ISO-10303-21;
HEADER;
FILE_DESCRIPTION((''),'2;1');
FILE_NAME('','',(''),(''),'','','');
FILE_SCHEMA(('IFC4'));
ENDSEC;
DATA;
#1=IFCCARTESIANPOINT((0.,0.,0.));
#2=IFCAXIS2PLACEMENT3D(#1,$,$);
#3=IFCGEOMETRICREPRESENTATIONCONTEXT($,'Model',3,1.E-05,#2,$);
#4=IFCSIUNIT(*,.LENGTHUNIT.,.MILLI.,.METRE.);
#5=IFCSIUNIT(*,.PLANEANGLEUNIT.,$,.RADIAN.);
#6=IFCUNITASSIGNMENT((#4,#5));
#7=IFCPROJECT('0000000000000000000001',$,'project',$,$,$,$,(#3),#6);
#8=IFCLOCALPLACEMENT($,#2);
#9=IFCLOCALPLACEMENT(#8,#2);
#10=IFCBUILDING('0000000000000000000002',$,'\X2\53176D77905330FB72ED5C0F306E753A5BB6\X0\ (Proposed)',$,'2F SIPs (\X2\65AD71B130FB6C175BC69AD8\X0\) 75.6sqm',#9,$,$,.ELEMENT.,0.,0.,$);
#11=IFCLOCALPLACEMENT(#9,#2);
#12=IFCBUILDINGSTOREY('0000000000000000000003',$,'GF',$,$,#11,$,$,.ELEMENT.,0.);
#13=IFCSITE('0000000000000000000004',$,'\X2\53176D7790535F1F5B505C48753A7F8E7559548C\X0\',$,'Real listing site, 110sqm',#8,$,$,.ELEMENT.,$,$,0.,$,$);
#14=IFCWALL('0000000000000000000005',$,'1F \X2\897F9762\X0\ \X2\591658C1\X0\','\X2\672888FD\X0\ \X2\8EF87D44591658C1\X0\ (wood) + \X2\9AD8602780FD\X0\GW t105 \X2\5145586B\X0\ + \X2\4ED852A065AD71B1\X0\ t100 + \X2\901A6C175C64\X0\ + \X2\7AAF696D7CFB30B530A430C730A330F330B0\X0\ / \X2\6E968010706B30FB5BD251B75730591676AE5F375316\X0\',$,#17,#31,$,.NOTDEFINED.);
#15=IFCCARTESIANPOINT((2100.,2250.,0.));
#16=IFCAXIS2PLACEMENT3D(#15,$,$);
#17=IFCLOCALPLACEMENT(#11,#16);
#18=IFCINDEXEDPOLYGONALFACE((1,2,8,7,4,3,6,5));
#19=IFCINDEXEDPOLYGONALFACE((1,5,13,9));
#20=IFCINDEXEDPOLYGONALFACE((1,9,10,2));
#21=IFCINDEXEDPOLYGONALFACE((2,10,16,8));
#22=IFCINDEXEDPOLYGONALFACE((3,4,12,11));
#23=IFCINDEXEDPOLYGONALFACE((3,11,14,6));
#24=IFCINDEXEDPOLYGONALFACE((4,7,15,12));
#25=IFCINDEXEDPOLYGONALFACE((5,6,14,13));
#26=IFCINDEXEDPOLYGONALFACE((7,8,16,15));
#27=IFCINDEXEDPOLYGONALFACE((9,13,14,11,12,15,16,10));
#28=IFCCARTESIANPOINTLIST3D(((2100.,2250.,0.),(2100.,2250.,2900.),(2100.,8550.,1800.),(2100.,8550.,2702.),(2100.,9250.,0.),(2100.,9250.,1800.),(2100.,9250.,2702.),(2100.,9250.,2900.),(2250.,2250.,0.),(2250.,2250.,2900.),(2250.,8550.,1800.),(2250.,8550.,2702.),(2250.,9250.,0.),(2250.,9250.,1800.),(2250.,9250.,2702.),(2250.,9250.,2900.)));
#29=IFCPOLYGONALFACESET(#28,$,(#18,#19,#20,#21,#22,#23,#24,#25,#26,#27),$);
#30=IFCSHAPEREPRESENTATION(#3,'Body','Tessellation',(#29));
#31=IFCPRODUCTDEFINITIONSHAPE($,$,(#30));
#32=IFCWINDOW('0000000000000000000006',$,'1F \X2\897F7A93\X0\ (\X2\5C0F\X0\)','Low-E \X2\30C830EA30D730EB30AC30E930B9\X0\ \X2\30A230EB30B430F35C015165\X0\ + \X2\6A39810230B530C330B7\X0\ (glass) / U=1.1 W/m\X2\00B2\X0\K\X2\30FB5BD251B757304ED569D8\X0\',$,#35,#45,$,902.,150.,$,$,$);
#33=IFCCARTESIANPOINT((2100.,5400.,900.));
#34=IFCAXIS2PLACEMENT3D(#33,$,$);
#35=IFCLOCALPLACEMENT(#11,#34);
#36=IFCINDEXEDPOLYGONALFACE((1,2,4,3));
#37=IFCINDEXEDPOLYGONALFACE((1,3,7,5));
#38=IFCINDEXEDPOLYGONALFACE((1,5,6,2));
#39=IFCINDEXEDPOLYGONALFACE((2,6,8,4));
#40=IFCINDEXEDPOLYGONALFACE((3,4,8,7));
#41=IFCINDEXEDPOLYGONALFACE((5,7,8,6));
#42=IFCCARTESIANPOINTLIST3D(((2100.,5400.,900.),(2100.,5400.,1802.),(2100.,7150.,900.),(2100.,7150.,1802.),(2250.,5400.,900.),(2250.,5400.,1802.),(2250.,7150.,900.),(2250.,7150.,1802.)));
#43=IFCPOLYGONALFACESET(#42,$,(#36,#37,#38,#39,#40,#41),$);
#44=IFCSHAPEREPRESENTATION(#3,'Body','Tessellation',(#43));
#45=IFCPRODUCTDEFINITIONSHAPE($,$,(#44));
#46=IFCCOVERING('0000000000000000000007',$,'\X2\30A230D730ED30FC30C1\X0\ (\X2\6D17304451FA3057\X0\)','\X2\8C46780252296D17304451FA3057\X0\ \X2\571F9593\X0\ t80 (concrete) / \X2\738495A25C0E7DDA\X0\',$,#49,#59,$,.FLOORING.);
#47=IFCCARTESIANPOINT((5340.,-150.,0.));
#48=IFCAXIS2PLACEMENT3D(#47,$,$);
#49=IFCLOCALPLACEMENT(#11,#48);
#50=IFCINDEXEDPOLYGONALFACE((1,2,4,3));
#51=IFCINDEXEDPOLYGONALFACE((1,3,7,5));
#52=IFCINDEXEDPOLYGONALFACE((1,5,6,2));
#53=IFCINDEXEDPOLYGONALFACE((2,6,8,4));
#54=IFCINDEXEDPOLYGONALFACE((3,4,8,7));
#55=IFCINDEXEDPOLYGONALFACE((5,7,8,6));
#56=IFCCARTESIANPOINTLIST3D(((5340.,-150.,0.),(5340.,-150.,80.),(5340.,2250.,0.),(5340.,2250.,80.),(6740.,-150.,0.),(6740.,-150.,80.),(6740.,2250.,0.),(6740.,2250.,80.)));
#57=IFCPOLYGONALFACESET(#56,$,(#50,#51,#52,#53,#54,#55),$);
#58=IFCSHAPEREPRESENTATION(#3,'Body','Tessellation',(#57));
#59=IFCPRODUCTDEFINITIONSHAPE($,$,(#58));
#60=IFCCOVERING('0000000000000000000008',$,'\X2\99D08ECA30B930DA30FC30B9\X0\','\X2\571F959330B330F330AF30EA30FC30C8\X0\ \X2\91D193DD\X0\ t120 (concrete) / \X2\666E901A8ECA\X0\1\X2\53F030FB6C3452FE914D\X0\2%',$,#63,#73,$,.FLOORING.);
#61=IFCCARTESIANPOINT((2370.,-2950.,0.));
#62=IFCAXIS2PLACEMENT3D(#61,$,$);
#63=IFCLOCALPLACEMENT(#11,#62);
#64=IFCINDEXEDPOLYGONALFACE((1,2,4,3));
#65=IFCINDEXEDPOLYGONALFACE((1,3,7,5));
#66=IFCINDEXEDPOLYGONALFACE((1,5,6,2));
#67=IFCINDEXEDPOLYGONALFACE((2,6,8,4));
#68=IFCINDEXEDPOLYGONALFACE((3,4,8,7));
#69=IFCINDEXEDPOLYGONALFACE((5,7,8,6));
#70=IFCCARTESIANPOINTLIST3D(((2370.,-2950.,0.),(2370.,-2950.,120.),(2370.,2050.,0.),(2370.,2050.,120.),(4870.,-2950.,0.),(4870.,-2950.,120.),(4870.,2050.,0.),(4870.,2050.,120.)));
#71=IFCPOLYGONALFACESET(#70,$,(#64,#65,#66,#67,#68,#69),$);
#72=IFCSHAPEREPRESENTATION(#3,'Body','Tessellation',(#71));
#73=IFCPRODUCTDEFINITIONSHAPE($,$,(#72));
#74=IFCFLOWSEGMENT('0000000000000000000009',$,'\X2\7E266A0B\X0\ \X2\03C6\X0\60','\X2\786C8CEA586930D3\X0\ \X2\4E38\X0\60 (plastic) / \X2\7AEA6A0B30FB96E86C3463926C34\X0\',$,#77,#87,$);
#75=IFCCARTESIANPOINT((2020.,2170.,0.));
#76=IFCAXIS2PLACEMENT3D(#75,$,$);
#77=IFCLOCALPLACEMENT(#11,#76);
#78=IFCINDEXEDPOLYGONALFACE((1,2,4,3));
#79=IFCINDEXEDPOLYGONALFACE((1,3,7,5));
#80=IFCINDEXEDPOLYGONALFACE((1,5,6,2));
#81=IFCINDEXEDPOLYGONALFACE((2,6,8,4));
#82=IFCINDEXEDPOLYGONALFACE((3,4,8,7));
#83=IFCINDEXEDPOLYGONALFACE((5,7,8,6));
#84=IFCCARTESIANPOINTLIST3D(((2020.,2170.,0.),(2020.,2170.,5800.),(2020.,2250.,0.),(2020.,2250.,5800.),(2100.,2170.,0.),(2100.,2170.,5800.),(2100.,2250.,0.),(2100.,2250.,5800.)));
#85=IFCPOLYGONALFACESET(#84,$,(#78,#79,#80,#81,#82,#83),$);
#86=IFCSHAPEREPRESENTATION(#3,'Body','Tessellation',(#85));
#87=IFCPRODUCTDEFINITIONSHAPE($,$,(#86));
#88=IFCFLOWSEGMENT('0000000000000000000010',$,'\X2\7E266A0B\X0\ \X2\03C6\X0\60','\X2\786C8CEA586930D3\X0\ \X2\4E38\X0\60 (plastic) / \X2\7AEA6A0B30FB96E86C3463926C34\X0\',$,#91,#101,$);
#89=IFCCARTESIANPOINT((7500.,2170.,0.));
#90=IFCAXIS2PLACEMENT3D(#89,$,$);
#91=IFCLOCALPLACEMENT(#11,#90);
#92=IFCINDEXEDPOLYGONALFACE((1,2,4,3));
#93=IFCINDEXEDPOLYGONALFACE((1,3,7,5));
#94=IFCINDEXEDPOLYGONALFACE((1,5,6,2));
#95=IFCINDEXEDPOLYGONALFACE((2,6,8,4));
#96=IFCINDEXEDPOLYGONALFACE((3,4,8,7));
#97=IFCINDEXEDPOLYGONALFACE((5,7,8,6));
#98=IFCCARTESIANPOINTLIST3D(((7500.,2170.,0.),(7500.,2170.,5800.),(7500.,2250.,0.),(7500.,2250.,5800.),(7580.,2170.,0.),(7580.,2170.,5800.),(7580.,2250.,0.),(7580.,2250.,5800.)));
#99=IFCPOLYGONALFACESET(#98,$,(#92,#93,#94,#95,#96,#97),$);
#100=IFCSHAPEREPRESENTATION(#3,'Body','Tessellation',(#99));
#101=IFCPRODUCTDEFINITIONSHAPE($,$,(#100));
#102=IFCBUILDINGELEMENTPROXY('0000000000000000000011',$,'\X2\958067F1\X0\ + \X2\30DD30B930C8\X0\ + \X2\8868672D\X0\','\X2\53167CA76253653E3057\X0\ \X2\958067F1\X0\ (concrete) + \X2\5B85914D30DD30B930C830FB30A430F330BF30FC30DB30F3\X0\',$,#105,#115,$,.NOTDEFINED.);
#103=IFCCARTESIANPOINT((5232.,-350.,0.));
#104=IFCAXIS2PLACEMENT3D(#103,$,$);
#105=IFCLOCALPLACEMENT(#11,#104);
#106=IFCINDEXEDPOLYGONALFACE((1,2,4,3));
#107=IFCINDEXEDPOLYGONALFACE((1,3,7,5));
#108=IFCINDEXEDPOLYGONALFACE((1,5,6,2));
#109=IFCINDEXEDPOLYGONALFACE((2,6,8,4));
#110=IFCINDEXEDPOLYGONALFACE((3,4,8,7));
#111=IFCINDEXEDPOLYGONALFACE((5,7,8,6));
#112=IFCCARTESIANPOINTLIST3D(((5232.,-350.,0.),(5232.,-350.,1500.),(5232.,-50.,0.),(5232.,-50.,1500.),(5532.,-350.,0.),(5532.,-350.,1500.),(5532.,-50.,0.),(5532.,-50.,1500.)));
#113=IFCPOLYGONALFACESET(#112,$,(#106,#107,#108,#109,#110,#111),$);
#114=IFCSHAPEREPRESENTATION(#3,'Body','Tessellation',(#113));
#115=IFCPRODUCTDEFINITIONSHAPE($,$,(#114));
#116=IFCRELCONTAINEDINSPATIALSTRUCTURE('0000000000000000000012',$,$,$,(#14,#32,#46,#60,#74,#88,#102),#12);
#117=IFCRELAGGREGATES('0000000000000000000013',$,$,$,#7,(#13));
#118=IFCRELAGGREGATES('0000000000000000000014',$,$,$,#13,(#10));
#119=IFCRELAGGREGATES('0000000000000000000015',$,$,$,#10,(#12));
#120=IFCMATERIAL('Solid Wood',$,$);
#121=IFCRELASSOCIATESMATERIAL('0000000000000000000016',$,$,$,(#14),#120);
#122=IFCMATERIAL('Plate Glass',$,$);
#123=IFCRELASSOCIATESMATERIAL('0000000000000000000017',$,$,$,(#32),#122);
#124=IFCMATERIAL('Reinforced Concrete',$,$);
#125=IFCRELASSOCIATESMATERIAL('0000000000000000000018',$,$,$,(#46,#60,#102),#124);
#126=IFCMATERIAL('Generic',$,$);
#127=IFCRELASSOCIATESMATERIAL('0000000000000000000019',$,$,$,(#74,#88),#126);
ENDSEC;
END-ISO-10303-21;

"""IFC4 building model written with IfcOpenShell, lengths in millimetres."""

from ifc_helpers import new_model, si_unit, frame, frame_2d, origin, place, context, project, spatial, rectangle, extrude, material, element, fill, save


model = new_model("IFC4")

# Units and contexts
model_context = context("Model", 3, precision=1e-05, world=origin())
ifc_project = project(units=[si_unit("LENGTHUNIT", "METRE", prefix="MILLI"), si_unit("PLANEANGLEUNIT", "RADIAN")], contexts=[model_context])

# Site, building, storey
site_placement = place(None, origin())
site = spatial("IfcSite", under=ifc_project, at=site_placement, Name="北海道弟子屈町美留和", ObjectType="Real listing site, 110sqm", CompositionType="ELEMENT", RefElevation=0.0)
building_placement = place(site_placement, origin())
building = spatial("IfcBuilding", under=site, at=building_placement, Name="北海道・狭小の町家 (Proposed)", ObjectType="2F SIPs (断熱・気密高) 75.6sqm", CompositionType="ELEMENT", ElevationOfRefHeight=0.0, ElevationOfTerrain=0.0)
storey_placement = place(building_placement, origin())
storey = spatial("IfcBuildingStorey", under=building, at=storey_placement, Name="GF", CompositionType="ELEMENT", Elevation=0.0)

# Shared definitions
ifc_material_1 = material(Name="Solid Wood")

# Shared definitions
ifc_material_2 = material(Name="Reinforced Concrete")

# Shared definitions
ifc_material_3 = material(Name="Plate Glass")

# Wall, opening, window
wall_1_placement = place(storey_placement, frame((2100.0, 2250.0, 0.0)))
wall_1 = element("IfcWall", 1, at=wall_1_placement, inside=storey, material=ifc_material_1, Name="1F 西面 外壁", Description="木製 軸組外壁 (wood) + 高性能GW t105 充填 + 付加断熱 t100 + 通気層 + 窯業系サイディング / 準耐火・寒冷地外皮強化", PredefinedType="NOTDEFINED", context=model_context, shape_type="SweptSolid", body=[
    extrude(rectangle(XDim=150.0, YDim=7000.0, at=frame_2d((75.0, 3500.0))), frame((2100.0, 2250.0, 0.0)), (0.0, 0.0, 1.0), 2900.0),
])
opening_1_placement = place(storey_placement, frame((2100.0, 5400.0, 900.0)))
opening_1 = element("IfcOpeningElement", 2, at=opening_1_placement, cuts=wall_1, PredefinedType="NOTDEFINED", context=model_context, shape_type="SweptSolid", body=[
    extrude(rectangle(XDim=150.0, YDim=1750.0, at=frame_2d((75.0, 875.0))), frame((2100.0, 5400.0, 900.0)), (0.0, 0.0, 1.0), 902.0),
])
window_1_placement = place(storey_placement, frame((2100.0, 5400.0, 900.0)))
window_1 = element("IfcWindow", 3, at=window_1_placement, inside=storey, material=ifc_material_3, Name="1F 西窓 (小)", Description="Low-E トリプルガラス アルゴン封入 + 樹脂サッシ (glass) / U=1.1 W/m²K・寒冷地仕様", OverallHeight=902.0, OverallWidth=150.0, context=model_context, shape_type="SweptSolid", body=[
    extrude(rectangle(XDim=150.0, YDim=1750.0, at=frame_2d((75.0, 875.0))), frame((2100.0, 5400.0, 900.0)), (0.0, 0.0, 1.0), 902.0),
])
fill(opening_1, window_1)

# Coverings
covering_1_placement = place(storey_placement, frame((5340.0, -150.0, 0.0)))
element("IfcCovering", 4, at=covering_1_placement, inside=storey, material=ifc_material_2, Name="アプローチ (洗い出し)", Description="豆砂利洗い出し 土間 t80 (concrete) / 玄関導線", PredefinedType="FLOORING", context=model_context, shape_type="SweptSolid", body=[
    extrude(rectangle(XDim=1400.0, YDim=2400.0, at=frame_2d((700.0, 1200.0))), frame((5340.0, -150.0, 0.0)), (0.0, 0.0, 1.0), 80.0),
])
covering_2_placement = place(storey_placement, frame((2370.0, -2950.0, 0.0)))
element("IfcCovering", 5, at=covering_2_placement, inside=storey, material=ifc_material_2, Name="駐車スペース", Description="土間コンクリート 金鏝 t120 (concrete) / 普通車1台・水勾配2%", PredefinedType="FLOORING", context=model_context, shape_type="SweptSolid", body=[
    extrude(rectangle(XDim=2500.0, YDim=5000.0, at=frame_2d((1250.0, 2500.0))), frame((2370.0, -2950.0, 0.0)), (0.0, 0.0, 1.0), 120.0),
])

# Flow segments
ifc_material_4 = material(Name="Generic")
flow_segment_1_placement = place(storey_placement, frame((2020.0, 2170.0, 0.0)))
element("IfcFlowSegment", 6, at=flow_segment_1_placement, inside=storey, material=ifc_material_4, Name="縦樋 φ60", Description="硬質塩ビ 丸60 (plastic) / 竪樋・雨水排水", context=model_context, shape_type="SweptSolid", body=[
    extrude(rectangle(XDim=80.0, YDim=80.0, at=frame_2d((40.0, 40.0))), frame((2020.0, 2170.0, 0.0)), (0.0, 0.0, 1.0), 5800.0),
])
flow_segment_2_placement = place(storey_placement, frame((7500.0, 2170.0, 0.0)))
element("IfcFlowSegment", 7, at=flow_segment_2_placement, inside=storey, material=ifc_material_4, Name="縦樋 φ60", Description="硬質塩ビ 丸60 (plastic) / 竪樋・雨水排水", context=model_context, shape_type="SweptSolid", body=[
    extrude(rectangle(XDim=80.0, YDim=80.0, at=frame_2d((40.0, 40.0))), frame((7500.0, 2170.0, 0.0)), (0.0, 0.0, 1.0), 5800.0),
])

# Building element proxy
proxy_placement = place(storey_placement, frame((5232.0, -350.0, 0.0)))
element("IfcBuildingElementProxy", 8, at=proxy_placement, inside=storey, material=ifc_material_2, Name="門柱 + ポスト + 表札", Description="化粧打放し 門柱 (concrete) + 宅配ポスト・インターホン", PredefinedType="NOTDEFINED", context=model_context, shape_type="SweptSolid", body=[
    extrude(rectangle(XDim=300.0, YDim=300.0, at=frame_2d((150.0, 150.0))), frame((5232.0, -350.0, 0.0)), (0.0, 0.0, 1.0), 1500.0),
])

save(model, "model.ifc")
